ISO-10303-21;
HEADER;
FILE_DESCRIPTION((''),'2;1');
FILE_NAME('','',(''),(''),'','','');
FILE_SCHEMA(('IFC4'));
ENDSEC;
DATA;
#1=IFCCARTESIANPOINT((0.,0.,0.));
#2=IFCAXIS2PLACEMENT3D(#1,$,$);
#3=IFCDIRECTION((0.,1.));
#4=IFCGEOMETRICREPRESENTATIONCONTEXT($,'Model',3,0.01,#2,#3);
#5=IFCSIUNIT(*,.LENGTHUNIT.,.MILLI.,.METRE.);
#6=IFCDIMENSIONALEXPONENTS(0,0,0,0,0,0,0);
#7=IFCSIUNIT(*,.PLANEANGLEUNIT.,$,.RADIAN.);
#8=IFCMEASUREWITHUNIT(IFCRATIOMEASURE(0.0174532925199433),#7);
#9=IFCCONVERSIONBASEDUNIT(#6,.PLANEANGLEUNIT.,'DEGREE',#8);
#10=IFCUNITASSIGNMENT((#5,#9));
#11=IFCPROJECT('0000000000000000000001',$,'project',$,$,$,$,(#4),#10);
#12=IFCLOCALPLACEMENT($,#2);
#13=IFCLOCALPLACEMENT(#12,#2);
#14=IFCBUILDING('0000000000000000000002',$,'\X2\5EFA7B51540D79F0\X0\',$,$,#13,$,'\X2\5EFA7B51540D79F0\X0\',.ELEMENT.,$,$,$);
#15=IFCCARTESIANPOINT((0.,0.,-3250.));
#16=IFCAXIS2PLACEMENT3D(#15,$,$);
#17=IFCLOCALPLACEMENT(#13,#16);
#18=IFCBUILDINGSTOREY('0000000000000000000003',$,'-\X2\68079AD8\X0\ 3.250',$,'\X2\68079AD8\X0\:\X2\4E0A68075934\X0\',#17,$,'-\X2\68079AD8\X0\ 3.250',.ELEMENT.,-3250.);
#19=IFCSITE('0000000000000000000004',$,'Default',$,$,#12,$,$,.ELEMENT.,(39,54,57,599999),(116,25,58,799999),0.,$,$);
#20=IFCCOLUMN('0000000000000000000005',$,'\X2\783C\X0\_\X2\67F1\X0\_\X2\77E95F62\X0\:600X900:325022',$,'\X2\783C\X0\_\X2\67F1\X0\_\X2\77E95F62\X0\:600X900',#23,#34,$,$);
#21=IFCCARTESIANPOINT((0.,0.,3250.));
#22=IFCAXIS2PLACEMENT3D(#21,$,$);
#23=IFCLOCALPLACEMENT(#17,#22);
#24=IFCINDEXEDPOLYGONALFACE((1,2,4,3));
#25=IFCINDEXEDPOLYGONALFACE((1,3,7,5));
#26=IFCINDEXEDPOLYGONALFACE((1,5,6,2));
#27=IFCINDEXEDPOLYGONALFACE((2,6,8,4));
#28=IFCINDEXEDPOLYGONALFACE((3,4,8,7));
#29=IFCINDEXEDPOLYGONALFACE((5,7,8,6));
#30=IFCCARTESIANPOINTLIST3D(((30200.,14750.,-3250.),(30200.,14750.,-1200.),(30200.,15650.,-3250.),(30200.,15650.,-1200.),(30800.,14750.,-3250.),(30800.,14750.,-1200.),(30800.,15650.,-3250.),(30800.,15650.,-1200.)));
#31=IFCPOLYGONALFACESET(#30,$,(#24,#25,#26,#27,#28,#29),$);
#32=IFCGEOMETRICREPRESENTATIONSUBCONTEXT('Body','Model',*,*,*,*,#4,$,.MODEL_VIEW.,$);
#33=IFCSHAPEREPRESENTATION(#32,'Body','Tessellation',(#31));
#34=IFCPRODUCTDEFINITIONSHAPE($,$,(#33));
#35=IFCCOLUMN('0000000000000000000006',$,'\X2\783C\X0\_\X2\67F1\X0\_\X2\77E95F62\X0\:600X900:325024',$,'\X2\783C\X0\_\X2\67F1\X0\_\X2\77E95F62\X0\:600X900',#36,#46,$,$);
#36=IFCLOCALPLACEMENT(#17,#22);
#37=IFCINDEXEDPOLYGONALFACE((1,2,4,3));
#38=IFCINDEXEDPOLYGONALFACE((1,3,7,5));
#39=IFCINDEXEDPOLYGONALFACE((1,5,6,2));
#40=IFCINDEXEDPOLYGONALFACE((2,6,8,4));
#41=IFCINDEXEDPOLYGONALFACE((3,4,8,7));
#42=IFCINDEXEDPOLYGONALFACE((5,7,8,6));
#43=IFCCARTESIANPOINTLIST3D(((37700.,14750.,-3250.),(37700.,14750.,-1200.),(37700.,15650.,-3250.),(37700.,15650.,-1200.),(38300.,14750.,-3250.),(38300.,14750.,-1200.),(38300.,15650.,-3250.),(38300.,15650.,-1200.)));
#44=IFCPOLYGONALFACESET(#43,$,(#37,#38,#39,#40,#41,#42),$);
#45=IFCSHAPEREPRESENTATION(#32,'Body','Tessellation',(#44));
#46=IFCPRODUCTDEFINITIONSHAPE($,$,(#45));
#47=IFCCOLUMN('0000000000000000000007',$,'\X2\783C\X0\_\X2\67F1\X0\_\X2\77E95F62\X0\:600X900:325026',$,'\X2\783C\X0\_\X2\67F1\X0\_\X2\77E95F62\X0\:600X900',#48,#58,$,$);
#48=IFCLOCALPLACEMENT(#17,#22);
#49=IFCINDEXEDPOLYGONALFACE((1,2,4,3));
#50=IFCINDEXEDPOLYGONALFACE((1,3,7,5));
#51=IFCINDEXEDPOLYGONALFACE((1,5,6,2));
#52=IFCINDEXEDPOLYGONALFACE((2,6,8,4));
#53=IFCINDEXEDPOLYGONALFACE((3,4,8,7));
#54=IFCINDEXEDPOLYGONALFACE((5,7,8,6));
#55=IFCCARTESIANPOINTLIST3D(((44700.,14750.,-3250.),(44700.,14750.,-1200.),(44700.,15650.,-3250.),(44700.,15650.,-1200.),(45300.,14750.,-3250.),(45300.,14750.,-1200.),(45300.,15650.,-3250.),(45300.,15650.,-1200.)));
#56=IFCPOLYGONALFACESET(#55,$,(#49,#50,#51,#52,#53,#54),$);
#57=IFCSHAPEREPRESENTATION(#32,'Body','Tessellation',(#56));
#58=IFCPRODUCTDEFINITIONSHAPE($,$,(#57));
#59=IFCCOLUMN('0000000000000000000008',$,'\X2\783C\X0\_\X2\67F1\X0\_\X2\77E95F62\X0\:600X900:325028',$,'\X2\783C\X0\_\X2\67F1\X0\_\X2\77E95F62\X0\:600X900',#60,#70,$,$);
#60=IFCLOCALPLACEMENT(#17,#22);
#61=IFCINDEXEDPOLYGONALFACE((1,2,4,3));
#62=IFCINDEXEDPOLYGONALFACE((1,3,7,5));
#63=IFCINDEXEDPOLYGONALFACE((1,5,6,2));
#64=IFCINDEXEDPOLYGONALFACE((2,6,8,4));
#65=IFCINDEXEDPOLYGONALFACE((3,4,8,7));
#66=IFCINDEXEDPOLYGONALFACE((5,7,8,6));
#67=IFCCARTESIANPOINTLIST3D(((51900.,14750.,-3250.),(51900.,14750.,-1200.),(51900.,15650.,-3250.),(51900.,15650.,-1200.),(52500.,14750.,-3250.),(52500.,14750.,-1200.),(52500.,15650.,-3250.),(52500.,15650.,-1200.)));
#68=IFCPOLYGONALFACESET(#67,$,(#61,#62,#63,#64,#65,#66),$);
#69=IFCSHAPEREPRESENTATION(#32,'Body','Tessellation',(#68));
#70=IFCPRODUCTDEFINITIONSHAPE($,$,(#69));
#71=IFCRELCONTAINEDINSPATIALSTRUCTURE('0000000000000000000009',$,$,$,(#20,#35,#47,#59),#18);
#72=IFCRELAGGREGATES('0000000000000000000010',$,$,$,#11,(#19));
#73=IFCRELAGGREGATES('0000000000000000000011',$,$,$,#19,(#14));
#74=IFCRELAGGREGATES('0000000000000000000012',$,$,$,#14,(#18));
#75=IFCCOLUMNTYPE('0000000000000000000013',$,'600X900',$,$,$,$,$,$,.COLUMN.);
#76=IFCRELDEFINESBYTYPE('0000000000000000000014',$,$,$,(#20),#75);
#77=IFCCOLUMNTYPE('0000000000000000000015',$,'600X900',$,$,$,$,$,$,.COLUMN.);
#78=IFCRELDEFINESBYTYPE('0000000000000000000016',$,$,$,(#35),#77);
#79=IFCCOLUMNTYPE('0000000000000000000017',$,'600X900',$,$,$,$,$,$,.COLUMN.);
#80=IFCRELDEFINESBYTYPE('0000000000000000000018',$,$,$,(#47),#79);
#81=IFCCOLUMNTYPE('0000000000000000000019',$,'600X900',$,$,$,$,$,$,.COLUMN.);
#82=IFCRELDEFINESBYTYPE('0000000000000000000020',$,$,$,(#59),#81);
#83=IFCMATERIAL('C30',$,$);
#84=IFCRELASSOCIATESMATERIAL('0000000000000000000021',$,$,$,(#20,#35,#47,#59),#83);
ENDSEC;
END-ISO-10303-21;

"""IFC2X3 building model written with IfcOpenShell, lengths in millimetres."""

from ifc_helpers import new_model, entity, si_unit, converted_unit, direction, frame, origin, origin_2d_with_axis, place, context, subcontext, project, spatial, rectangle, extrude, source, transform, mapped, material, type_object, type_shapes, element, save


model = new_model("IFC2X3")

# Units and contexts
model_context = context("Model", 3, precision=0.01, world=origin(), true_north=direction((0.0, 1.0)))
body_context = subcontext(model_context, "Body", "Model", "MODEL_VIEW")
ifc_project = project(units=[si_unit("LENGTHUNIT", "METRE", prefix="MILLI"), converted_unit("PLANEANGLEUNIT", "DEGREE", entity("IfcRatioMeasure", 0.0174532925199433), si_unit("PLANEANGLEUNIT", "RADIAN"), dimensions=[0, 0, 0, 0, 0, 0, 0])], contexts=[model_context])

# Site, building, storey
site_placement = place(None, origin())
site = spatial("IfcSite", under=ifc_project, at=site_placement, Name="Default", CompositionType="ELEMENT", RefLatitude=(39, 54, 57, 599999), RefLongitude=(116, 25, 58, 799999), RefElevation=0.0)
building_placement = place(site_placement, origin())
building = spatial("IfcBuilding", under=site, at=building_placement, Name="建筑名称", LongName="建筑名称", CompositionType="ELEMENT")
storey_placement = place(building_placement, frame((0.0, 0.0, -3250.0)))
storey = spatial("IfcBuildingStorey", under=building, at=storey_placement, Name="-标高 3.250", ObjectType="标高:上标头", LongName="-标高 3.250", CompositionType="ELEMENT", Elevation=-3250.0)

# Columns
ifc_material_1 = material(Name="C30")
column_type_1 = type_object("IfcColumnType", Name="600X900", PredefinedType="COLUMN")
shared_shape_1 = source(origin(), body_context, "Body", "SweptSolid", [
    extrude(rectangle(XDim=900.0, YDim=600.0, at=origin_2d_with_axis()), frame((30500.0, 15200.0, -3250.0), z_axis=(0.0, 0.0, 1.0), x_axis=(0.0, -1.0, 0.0)), (0.0, 0.0, 1.0), 2050.0),
])
type_shapes(column_type_1, [shared_shape_1])
column_1_placement = place(storey_placement, frame((0.0, 0.0, 3250.0)))
element("IfcColumn", 1, at=column_1_placement, inside=storey, type_object=column_type_1, material=ifc_material_1, Name="砼_柱_矩形:600X900:325022", ObjectType="砼_柱_矩形:600X900", context=body_context, shape_type="MappedRepresentation", body=[
    mapped(shared_shape_1, transform((0.0, 0.0, 0.0), scale=1.0)),
])
column_type_2 = type_object("IfcColumnType", Name="600X900", PredefinedType="COLUMN")
shared_shape_2 = source(origin(), body_context, "Body", "SweptSolid", [
    extrude(rectangle(XDim=900.0, YDim=600.0, at=origin_2d_with_axis()), frame((38000.0, 15200.0, -3250.0), z_axis=(0.0, 0.0, 1.0), x_axis=(0.0, -1.0, 0.0)), (0.0, 0.0, 1.0), 2050.0),
])
type_shapes(column_type_2, [shared_shape_2])
column_2_placement = place(storey_placement, frame((0.0, 0.0, 3250.0)))
element("IfcColumn", 2, at=column_2_placement, inside=storey, type_object=column_type_2, material=ifc_material_1, Name="砼_柱_矩形:600X900:325024", ObjectType="砼_柱_矩形:600X900", context=body_context, shape_type="MappedRepresentation", body=[
    mapped(shared_shape_2, transform((0.0, 0.0, 0.0), scale=1.0)),
])
column_type_3 = type_object("IfcColumnType", Name="600X900", PredefinedType="COLUMN")
shared_shape_3 = source(origin(), body_context, "Body", "SweptSolid", [
    extrude(rectangle(XDim=900.0, YDim=600.0, at=origin_2d_with_axis()), frame((45000.0, 15200.0, -3250.0), z_axis=(0.0, 0.0, 1.0), x_axis=(0.0, -1.0, 0.0)), (0.0, 0.0, 1.0), 2050.0),
])
type_shapes(column_type_3, [shared_shape_3])
column_3_placement = place(storey_placement, frame((0.0, 0.0, 3250.0)))
element("IfcColumn", 3, at=column_3_placement, inside=storey, type_object=column_type_3, material=ifc_material_1, Name="砼_柱_矩形:600X900:325026", ObjectType="砼_柱_矩形:600X900", context=body_context, shape_type="MappedRepresentation", body=[
    mapped(shared_shape_3, transform((0.0, 0.0, 0.0), scale=1.0)),
])
column_type_4 = type_object("IfcColumnType", Name="600X900", PredefinedType="COLUMN")
shared_shape_4 = source(origin(), body_context, "Body", "SweptSolid", [
    extrude(rectangle(XDim=900.0, YDim=600.0, at=origin_2d_with_axis()), frame((52200.0, 15200.0, -3250.0), z_axis=(0.0, 0.0, 1.0), x_axis=(0.0, -1.0, 0.0)), (0.0, 0.0, 1.0), 2050.0),
])
type_shapes(column_type_4, [shared_shape_4])
column_4_placement = place(storey_placement, frame((0.0, 0.0, 3250.0)))
element("IfcColumn", 4, at=column_4_placement, inside=storey, type_object=column_type_4, material=ifc_material_1, Name="砼_柱_矩形:600X900:325028", ObjectType="砼_柱_矩形:600X900", context=body_context, shape_type="MappedRepresentation", body=[
    mapped(shared_shape_4, transform((0.0, 0.0, 0.0), scale=1.0)),
])

save(model, "model.ifc")
